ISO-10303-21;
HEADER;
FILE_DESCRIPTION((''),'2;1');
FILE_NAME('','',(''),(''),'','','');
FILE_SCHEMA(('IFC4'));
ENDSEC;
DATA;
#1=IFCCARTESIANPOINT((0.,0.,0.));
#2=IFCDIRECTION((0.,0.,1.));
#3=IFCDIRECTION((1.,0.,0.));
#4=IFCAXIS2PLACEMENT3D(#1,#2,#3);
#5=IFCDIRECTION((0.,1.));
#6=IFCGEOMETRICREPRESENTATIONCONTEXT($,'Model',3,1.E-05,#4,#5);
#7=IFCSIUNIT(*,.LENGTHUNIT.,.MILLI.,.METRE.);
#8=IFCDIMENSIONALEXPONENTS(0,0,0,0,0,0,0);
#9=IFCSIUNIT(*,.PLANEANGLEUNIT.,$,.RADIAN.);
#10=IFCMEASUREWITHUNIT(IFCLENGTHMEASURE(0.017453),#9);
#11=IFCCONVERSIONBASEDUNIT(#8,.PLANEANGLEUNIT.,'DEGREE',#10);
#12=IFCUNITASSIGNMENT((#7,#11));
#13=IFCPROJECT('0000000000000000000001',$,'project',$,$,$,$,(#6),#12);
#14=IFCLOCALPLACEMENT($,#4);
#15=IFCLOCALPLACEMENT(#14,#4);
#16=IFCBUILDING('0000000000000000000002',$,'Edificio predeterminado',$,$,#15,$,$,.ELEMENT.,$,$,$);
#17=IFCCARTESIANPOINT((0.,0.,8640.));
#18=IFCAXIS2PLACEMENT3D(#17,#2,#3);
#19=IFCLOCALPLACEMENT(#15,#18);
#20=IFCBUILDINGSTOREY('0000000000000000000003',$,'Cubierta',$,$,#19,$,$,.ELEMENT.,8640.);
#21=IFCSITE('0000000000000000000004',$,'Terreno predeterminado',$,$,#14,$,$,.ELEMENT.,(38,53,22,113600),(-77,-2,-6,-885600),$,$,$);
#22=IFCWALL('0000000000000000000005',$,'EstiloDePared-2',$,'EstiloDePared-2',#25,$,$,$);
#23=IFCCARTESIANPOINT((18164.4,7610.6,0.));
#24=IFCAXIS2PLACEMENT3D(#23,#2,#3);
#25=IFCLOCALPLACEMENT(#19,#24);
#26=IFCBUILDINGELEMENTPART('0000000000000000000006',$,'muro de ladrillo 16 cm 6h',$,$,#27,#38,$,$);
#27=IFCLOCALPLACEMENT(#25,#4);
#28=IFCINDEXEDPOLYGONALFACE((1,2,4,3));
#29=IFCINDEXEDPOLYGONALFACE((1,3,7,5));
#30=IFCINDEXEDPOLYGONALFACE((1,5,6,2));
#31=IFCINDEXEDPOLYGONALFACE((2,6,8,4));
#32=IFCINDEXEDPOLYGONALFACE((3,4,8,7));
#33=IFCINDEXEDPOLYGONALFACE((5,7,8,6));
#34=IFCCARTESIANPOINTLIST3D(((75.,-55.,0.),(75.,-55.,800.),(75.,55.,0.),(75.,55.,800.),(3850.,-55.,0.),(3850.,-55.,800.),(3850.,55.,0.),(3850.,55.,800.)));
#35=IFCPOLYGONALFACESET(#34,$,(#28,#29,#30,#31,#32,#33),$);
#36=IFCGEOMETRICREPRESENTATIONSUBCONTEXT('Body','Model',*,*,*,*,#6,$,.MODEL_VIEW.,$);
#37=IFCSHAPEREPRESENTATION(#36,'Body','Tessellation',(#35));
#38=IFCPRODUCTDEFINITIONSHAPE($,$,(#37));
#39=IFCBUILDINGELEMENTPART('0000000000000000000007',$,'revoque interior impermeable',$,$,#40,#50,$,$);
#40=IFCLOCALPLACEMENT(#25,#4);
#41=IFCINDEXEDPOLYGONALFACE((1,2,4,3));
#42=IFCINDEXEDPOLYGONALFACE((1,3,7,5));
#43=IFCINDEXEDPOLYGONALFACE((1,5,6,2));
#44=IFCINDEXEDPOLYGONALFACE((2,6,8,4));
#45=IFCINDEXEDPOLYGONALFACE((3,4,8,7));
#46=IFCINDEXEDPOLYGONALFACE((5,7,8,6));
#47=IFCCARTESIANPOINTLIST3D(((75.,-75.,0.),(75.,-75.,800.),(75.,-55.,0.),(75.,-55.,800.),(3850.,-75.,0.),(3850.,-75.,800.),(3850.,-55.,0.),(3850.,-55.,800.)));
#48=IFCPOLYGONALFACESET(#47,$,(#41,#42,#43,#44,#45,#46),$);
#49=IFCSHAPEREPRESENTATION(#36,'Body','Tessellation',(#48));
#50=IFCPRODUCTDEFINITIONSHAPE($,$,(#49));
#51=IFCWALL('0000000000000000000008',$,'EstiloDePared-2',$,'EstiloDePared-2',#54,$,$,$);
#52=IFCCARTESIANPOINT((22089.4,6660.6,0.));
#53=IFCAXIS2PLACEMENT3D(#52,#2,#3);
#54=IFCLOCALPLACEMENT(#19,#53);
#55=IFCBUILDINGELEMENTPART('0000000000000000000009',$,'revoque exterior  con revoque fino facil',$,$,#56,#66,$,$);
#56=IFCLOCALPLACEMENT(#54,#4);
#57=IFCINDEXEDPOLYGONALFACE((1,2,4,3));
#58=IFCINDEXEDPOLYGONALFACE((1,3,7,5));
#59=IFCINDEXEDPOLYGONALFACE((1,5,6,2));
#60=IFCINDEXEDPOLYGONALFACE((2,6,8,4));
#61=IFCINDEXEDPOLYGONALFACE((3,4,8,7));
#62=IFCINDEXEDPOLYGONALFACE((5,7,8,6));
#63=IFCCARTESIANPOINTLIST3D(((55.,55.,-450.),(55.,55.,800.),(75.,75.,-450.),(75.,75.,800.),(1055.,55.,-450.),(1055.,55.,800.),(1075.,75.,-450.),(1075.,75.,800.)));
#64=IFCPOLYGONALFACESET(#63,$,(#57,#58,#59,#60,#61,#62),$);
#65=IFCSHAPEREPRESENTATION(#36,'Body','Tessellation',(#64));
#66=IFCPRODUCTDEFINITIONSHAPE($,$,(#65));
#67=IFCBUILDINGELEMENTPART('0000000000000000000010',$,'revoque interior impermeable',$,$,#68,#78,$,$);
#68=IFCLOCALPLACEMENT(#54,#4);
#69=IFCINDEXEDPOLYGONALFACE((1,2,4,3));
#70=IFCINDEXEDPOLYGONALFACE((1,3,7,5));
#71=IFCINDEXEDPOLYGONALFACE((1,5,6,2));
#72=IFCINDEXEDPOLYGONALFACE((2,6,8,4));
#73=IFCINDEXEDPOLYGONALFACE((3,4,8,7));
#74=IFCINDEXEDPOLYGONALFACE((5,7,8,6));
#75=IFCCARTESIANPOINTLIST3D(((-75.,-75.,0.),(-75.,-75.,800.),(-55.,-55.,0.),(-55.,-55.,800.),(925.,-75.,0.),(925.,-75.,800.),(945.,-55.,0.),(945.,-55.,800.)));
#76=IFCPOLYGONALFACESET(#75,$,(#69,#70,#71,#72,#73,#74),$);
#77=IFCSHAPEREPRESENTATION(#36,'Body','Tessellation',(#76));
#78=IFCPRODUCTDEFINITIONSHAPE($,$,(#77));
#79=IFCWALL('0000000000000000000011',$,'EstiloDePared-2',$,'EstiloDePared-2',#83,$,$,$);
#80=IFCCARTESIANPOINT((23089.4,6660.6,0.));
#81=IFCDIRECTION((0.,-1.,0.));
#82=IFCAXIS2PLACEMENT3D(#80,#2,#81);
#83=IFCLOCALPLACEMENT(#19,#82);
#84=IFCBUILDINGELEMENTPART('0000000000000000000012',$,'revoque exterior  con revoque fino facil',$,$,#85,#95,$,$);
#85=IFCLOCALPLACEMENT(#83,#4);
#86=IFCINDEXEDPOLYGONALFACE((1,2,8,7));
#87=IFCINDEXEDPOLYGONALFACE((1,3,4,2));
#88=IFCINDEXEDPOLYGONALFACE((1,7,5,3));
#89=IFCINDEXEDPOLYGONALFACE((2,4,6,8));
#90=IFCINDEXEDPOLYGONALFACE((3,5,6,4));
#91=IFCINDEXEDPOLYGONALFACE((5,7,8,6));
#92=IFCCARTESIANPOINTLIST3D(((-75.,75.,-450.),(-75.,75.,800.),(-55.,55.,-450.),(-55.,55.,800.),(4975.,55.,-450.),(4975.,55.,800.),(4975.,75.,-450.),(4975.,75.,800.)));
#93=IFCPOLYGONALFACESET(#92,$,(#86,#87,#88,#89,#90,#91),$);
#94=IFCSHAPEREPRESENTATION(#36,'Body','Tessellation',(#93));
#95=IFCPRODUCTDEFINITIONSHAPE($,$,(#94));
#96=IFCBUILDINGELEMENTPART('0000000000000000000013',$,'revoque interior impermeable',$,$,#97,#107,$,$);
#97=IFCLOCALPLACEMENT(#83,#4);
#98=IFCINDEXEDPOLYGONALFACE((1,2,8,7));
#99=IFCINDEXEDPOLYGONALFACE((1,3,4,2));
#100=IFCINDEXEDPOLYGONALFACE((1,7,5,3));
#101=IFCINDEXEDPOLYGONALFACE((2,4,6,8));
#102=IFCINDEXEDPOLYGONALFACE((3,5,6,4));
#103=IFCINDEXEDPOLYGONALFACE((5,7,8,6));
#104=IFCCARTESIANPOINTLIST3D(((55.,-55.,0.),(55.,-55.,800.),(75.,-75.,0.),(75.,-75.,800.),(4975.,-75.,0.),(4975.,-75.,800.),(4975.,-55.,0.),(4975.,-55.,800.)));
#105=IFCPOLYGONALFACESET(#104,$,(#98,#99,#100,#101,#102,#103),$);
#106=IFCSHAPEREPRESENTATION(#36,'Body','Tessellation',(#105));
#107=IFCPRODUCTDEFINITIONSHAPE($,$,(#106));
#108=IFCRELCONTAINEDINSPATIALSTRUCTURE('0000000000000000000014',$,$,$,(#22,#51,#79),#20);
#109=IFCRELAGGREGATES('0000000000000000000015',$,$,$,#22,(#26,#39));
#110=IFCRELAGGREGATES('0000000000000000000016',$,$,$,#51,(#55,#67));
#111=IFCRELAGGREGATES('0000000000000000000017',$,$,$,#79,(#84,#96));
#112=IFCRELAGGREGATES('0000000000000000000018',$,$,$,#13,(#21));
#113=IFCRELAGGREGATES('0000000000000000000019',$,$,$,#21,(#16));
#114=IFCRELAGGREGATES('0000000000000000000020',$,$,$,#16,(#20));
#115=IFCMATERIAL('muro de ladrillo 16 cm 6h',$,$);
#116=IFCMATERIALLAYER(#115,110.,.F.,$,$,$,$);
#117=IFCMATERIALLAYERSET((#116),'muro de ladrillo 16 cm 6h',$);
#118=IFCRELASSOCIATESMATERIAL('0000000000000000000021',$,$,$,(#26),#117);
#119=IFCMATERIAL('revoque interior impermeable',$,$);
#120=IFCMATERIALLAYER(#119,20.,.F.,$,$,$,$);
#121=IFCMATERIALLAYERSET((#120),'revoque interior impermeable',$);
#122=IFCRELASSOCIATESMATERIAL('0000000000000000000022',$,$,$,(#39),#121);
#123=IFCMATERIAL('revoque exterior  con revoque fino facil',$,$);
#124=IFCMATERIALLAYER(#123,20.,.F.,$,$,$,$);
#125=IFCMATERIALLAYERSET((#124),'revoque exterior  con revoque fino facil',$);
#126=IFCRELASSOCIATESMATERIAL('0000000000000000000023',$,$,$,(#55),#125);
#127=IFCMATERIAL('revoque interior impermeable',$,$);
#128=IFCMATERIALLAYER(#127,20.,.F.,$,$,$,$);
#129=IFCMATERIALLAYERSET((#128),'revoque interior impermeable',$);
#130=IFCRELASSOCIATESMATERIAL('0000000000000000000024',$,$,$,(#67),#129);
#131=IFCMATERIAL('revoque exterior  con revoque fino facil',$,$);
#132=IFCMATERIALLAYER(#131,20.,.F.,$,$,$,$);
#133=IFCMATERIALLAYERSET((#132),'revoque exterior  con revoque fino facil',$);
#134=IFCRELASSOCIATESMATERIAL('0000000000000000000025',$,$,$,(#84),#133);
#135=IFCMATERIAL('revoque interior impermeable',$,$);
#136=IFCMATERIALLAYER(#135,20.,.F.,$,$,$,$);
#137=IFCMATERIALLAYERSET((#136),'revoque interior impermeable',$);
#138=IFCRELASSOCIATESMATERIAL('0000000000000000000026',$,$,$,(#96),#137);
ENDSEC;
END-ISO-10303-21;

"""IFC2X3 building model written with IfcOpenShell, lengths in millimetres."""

from ifc_helpers import new_model, entity, si_unit, converted_unit, direction, frame, origin_with_axes, place, context, subcontext, project, spatial, polyline, outline, extrude, material, layer, layer_set, layer_usage, element, aggregate, save


model = new_model("IFC2X3")

# Units and contexts
model_context = context("Model", 3, precision=1e-05, world=origin_with_axes(), true_north=direction((0.0, 1.0)))
body_context = subcontext(model_context, "Body", "Model", "MODEL_VIEW")
ifc_project = project(units=[si_unit("LENGTHUNIT", "METRE", prefix="MILLI"), converted_unit("PLANEANGLEUNIT", "DEGREE", entity("IfcLengthMeasure", 0.017453), si_unit("PLANEANGLEUNIT", "RADIAN"), dimensions=[0, 0, 0, 0, 0, 0, 0])], contexts=[model_context])

# Site, building, storey
site_placement = place(None, origin_with_axes())
site = spatial("IfcSite", under=ifc_project, at=site_placement, Name="Terreno predeterminado", CompositionType="ELEMENT", RefLatitude=(38, 53, 22, 113600), RefLongitude=(-77, -2, -6, -885600))
building_placement = place(site_placement, origin_with_axes())
building = spatial("IfcBuilding", under=site, at=building_placement, Name="Edificio predeterminado", CompositionType="ELEMENT")
storey_placement = place(building_placement, frame((0.0, 0.0, 8640.0), z_axis=(0.0, 0.0, 1.0), x_axis=(1.0, 0.0, 0.0)))
storey = spatial("IfcBuildingStorey", under=building, at=storey_placement, Name="Cubierta", CompositionType="ELEMENT", Elevation=8640.0)

# Walls, building element parts
wall_1_placement = place(storey_placement, frame((18164.4, 7610.6, 0.0), z_axis=(0.0, 0.0, 1.0), x_axis=(1.0, 0.0, 0.0)))
wall_1 = element("IfcWall", 1, at=wall_1_placement, inside=storey, Name="EstiloDePared-2", ObjectType="EstiloDePared-2")
ifc_material_1 = material(Name="muro de ladrillo 16 cm 6h")
ifc_layer_1 = layer(ifc_material_1, 110.0, ventilated=False)
ifc_layer_set_1 = layer_set([ifc_layer_1], Name="muro de ladrillo 16 cm 6h")
ifc_layer_usage_1 = layer_usage(ifc_layer_set_1, "AXIS2", "NEGATIVE", -55.0)
building_element_part_1_placement = place(wall_1_placement, origin_with_axes())
building_element_part_1 = element("IfcBuildingElementPart", 2, at=building_element_part_1_placement, material=ifc_layer_usage_1, Name="muro de ladrillo 16 cm 6h", context=body_context, shape_type="SweptSolid", body=[
    extrude(outline(polyline([(3850.0, 55.0), (3850.0, -55.0), (75.0, -55.0), (75.0, 55.0), (3850.0, 55.0)])), origin_with_axes(), (0.0, 0.0, 1.0), 800.0),
])
ifc_material_2 = material(Name="revoque interior impermeable")
ifc_layer_2 = layer(ifc_material_2, 20.0, ventilated=False)
ifc_layer_set_2 = layer_set([ifc_layer_2], Name="revoque interior impermeable")
ifc_layer_usage_2 = layer_usage(ifc_layer_set_2, "AXIS2", "NEGATIVE", 55.0)
building_element_part_2_placement = place(wall_1_placement, origin_with_axes())
building_element_part_2 = element("IfcBuildingElementPart", 3, at=building_element_part_2_placement, material=ifc_layer_usage_2, Name="revoque interior impermeable", context=body_context, shape_type="SweptSolid", body=[
    extrude(outline(polyline([(3850.0, -55.0), (3850.0, -75.0), (75.0, -75.0), (75.0, -55.0), (3850.0, -55.0)])), origin_with_axes(), (0.0, 0.0, 1.0), 800.0),
])
aggregate(wall_1, [building_element_part_1, building_element_part_2])
wall_2_placement = place(storey_placement, frame((22089.4, 6660.6, 0.0), z_axis=(0.0, 0.0, 1.0), x_axis=(1.0, 0.0, 0.0)))
wall_2 = element("IfcWall", 4, at=wall_2_placement, inside=storey, Name="EstiloDePared-2", ObjectType="EstiloDePared-2")
ifc_material_3 = material(Name="revoque exterior  con revoque fino facil")
ifc_layer_3 = layer(ifc_material_3, 20.0, ventilated=False)
ifc_layer_set_3 = layer_set([ifc_layer_3], Name="revoque exterior  con revoque fino facil")
ifc_layer_usage_3 = layer_usage(ifc_layer_set_3, "AXIS2", "NEGATIVE", -75.0)
building_element_part_3_placement = place(wall_2_placement, origin_with_axes())
building_element_part_3 = element("IfcBuildingElementPart", 5, at=building_element_part_3_placement, material=ifc_layer_usage_3, Name="revoque exterior  con revoque fino facil", context=body_context, shape_type="SweptSolid", body=[
    extrude(outline(polyline([(1075.0, 75.0), (1055.0, 55.0), (55.0, 55.0), (75.0, 75.0), (1075.0, 75.0)])), frame((0.0, 0.0, -450.0), z_axis=(0.0, 0.0, 1.0), x_axis=(1.0, 0.0, 0.0)), (0.0, 0.0, 1.0), 1250.0),
])
ifc_material_4 = material(Name="revoque interior impermeable")
ifc_layer_4 = layer(ifc_material_4, 20.0, ventilated=False)
ifc_layer_set_4 = layer_set([ifc_layer_4], Name="revoque interior impermeable")
ifc_layer_usage_4 = layer_usage(ifc_layer_set_4, "AXIS2", "NEGATIVE", 55.0)
building_element_part_4_placement = place(wall_2_placement, origin_with_axes())
building_element_part_4 = element("IfcBuildingElementPart", 6, at=building_element_part_4_placement, material=ifc_layer_usage_4, Name="revoque interior impermeable", context=body_context, shape_type="SweptSolid", body=[
    extrude(outline(polyline([(945.0, -55.0), (925.0, -75.0), (-75.0, -75.0), (-55.0, -55.0), (945.0, -55.0)])), origin_with_axes(), (0.0, 0.0, 1.0), 800.0),
])
aggregate(wall_2, [building_element_part_3, building_element_part_4])
wall_3_placement = place(storey_placement, frame((23089.4, 6660.6, 0.0), z_axis=(0.0, 0.0, 1.0), x_axis=(0.0, -1.0, 0.0)))
wall_3 = element("IfcWall", 7, at=wall_3_placement, inside=storey, Name="EstiloDePared-2", ObjectType="EstiloDePared-2")
ifc_material_5 = material(Name="revoque exterior  con revoque fino facil")
ifc_layer_5 = layer(ifc_material_5, 20.0, ventilated=False)
ifc_layer_set_5 = layer_set([ifc_layer_5], Name="revoque exterior  con revoque fino facil")
ifc_layer_usage_5 = layer_usage(ifc_layer_set_5, "AXIS2", "NEGATIVE", -75.0)
building_element_part_5_placement = place(wall_3_placement, origin_with_axes())
building_element_part_5 = element("IfcBuildingElementPart", 8, at=building_element_part_5_placement, material=ifc_layer_usage_5, Name="revoque exterior  con revoque fino facil", context=body_context, shape_type="SweptSolid", body=[
    extrude(outline(polyline([(4975.0, 75.0), (4975.0, 55.0), (-55.0, 55.0), (-75.0, 75.0), (4975.0, 75.0)])), frame((0.0, 0.0, -450.0), z_axis=(0.0, 0.0, 1.0), x_axis=(1.0, 0.0, 0.0)), (0.0, 0.0, 1.0), 1250.0),
])
ifc_material_6 = material(Name="revoque interior impermeable")
ifc_layer_6 = layer(ifc_material_6, 20.0, ventilated=False)
ifc_layer_set_6 = layer_set([ifc_layer_6], Name="revoque interior impermeable")
ifc_layer_usage_6 = layer_usage(ifc_layer_set_6, "AXIS2", "NEGATIVE", 55.0)
building_element_part_6_placement = place(wall_3_placement, origin_with_axes())
building_element_part_6 = element("IfcBuildingElementPart", 9, at=building_element_part_6_placement, material=ifc_layer_usage_6, Name="revoque interior impermeable", context=body_context, shape_type="SweptSolid", body=[
    extrude(outline(polyline([(4975.0, -55.0), (4975.0, -75.0), (75.0, -75.0), (55.0, -55.0), (4975.0, -55.0)])), origin_with_axes(), (0.0, 0.0, 1.0), 800.0),
])
aggregate(wall_3, [building_element_part_5, building_element_part_6])

save(model, "model.ifc")
